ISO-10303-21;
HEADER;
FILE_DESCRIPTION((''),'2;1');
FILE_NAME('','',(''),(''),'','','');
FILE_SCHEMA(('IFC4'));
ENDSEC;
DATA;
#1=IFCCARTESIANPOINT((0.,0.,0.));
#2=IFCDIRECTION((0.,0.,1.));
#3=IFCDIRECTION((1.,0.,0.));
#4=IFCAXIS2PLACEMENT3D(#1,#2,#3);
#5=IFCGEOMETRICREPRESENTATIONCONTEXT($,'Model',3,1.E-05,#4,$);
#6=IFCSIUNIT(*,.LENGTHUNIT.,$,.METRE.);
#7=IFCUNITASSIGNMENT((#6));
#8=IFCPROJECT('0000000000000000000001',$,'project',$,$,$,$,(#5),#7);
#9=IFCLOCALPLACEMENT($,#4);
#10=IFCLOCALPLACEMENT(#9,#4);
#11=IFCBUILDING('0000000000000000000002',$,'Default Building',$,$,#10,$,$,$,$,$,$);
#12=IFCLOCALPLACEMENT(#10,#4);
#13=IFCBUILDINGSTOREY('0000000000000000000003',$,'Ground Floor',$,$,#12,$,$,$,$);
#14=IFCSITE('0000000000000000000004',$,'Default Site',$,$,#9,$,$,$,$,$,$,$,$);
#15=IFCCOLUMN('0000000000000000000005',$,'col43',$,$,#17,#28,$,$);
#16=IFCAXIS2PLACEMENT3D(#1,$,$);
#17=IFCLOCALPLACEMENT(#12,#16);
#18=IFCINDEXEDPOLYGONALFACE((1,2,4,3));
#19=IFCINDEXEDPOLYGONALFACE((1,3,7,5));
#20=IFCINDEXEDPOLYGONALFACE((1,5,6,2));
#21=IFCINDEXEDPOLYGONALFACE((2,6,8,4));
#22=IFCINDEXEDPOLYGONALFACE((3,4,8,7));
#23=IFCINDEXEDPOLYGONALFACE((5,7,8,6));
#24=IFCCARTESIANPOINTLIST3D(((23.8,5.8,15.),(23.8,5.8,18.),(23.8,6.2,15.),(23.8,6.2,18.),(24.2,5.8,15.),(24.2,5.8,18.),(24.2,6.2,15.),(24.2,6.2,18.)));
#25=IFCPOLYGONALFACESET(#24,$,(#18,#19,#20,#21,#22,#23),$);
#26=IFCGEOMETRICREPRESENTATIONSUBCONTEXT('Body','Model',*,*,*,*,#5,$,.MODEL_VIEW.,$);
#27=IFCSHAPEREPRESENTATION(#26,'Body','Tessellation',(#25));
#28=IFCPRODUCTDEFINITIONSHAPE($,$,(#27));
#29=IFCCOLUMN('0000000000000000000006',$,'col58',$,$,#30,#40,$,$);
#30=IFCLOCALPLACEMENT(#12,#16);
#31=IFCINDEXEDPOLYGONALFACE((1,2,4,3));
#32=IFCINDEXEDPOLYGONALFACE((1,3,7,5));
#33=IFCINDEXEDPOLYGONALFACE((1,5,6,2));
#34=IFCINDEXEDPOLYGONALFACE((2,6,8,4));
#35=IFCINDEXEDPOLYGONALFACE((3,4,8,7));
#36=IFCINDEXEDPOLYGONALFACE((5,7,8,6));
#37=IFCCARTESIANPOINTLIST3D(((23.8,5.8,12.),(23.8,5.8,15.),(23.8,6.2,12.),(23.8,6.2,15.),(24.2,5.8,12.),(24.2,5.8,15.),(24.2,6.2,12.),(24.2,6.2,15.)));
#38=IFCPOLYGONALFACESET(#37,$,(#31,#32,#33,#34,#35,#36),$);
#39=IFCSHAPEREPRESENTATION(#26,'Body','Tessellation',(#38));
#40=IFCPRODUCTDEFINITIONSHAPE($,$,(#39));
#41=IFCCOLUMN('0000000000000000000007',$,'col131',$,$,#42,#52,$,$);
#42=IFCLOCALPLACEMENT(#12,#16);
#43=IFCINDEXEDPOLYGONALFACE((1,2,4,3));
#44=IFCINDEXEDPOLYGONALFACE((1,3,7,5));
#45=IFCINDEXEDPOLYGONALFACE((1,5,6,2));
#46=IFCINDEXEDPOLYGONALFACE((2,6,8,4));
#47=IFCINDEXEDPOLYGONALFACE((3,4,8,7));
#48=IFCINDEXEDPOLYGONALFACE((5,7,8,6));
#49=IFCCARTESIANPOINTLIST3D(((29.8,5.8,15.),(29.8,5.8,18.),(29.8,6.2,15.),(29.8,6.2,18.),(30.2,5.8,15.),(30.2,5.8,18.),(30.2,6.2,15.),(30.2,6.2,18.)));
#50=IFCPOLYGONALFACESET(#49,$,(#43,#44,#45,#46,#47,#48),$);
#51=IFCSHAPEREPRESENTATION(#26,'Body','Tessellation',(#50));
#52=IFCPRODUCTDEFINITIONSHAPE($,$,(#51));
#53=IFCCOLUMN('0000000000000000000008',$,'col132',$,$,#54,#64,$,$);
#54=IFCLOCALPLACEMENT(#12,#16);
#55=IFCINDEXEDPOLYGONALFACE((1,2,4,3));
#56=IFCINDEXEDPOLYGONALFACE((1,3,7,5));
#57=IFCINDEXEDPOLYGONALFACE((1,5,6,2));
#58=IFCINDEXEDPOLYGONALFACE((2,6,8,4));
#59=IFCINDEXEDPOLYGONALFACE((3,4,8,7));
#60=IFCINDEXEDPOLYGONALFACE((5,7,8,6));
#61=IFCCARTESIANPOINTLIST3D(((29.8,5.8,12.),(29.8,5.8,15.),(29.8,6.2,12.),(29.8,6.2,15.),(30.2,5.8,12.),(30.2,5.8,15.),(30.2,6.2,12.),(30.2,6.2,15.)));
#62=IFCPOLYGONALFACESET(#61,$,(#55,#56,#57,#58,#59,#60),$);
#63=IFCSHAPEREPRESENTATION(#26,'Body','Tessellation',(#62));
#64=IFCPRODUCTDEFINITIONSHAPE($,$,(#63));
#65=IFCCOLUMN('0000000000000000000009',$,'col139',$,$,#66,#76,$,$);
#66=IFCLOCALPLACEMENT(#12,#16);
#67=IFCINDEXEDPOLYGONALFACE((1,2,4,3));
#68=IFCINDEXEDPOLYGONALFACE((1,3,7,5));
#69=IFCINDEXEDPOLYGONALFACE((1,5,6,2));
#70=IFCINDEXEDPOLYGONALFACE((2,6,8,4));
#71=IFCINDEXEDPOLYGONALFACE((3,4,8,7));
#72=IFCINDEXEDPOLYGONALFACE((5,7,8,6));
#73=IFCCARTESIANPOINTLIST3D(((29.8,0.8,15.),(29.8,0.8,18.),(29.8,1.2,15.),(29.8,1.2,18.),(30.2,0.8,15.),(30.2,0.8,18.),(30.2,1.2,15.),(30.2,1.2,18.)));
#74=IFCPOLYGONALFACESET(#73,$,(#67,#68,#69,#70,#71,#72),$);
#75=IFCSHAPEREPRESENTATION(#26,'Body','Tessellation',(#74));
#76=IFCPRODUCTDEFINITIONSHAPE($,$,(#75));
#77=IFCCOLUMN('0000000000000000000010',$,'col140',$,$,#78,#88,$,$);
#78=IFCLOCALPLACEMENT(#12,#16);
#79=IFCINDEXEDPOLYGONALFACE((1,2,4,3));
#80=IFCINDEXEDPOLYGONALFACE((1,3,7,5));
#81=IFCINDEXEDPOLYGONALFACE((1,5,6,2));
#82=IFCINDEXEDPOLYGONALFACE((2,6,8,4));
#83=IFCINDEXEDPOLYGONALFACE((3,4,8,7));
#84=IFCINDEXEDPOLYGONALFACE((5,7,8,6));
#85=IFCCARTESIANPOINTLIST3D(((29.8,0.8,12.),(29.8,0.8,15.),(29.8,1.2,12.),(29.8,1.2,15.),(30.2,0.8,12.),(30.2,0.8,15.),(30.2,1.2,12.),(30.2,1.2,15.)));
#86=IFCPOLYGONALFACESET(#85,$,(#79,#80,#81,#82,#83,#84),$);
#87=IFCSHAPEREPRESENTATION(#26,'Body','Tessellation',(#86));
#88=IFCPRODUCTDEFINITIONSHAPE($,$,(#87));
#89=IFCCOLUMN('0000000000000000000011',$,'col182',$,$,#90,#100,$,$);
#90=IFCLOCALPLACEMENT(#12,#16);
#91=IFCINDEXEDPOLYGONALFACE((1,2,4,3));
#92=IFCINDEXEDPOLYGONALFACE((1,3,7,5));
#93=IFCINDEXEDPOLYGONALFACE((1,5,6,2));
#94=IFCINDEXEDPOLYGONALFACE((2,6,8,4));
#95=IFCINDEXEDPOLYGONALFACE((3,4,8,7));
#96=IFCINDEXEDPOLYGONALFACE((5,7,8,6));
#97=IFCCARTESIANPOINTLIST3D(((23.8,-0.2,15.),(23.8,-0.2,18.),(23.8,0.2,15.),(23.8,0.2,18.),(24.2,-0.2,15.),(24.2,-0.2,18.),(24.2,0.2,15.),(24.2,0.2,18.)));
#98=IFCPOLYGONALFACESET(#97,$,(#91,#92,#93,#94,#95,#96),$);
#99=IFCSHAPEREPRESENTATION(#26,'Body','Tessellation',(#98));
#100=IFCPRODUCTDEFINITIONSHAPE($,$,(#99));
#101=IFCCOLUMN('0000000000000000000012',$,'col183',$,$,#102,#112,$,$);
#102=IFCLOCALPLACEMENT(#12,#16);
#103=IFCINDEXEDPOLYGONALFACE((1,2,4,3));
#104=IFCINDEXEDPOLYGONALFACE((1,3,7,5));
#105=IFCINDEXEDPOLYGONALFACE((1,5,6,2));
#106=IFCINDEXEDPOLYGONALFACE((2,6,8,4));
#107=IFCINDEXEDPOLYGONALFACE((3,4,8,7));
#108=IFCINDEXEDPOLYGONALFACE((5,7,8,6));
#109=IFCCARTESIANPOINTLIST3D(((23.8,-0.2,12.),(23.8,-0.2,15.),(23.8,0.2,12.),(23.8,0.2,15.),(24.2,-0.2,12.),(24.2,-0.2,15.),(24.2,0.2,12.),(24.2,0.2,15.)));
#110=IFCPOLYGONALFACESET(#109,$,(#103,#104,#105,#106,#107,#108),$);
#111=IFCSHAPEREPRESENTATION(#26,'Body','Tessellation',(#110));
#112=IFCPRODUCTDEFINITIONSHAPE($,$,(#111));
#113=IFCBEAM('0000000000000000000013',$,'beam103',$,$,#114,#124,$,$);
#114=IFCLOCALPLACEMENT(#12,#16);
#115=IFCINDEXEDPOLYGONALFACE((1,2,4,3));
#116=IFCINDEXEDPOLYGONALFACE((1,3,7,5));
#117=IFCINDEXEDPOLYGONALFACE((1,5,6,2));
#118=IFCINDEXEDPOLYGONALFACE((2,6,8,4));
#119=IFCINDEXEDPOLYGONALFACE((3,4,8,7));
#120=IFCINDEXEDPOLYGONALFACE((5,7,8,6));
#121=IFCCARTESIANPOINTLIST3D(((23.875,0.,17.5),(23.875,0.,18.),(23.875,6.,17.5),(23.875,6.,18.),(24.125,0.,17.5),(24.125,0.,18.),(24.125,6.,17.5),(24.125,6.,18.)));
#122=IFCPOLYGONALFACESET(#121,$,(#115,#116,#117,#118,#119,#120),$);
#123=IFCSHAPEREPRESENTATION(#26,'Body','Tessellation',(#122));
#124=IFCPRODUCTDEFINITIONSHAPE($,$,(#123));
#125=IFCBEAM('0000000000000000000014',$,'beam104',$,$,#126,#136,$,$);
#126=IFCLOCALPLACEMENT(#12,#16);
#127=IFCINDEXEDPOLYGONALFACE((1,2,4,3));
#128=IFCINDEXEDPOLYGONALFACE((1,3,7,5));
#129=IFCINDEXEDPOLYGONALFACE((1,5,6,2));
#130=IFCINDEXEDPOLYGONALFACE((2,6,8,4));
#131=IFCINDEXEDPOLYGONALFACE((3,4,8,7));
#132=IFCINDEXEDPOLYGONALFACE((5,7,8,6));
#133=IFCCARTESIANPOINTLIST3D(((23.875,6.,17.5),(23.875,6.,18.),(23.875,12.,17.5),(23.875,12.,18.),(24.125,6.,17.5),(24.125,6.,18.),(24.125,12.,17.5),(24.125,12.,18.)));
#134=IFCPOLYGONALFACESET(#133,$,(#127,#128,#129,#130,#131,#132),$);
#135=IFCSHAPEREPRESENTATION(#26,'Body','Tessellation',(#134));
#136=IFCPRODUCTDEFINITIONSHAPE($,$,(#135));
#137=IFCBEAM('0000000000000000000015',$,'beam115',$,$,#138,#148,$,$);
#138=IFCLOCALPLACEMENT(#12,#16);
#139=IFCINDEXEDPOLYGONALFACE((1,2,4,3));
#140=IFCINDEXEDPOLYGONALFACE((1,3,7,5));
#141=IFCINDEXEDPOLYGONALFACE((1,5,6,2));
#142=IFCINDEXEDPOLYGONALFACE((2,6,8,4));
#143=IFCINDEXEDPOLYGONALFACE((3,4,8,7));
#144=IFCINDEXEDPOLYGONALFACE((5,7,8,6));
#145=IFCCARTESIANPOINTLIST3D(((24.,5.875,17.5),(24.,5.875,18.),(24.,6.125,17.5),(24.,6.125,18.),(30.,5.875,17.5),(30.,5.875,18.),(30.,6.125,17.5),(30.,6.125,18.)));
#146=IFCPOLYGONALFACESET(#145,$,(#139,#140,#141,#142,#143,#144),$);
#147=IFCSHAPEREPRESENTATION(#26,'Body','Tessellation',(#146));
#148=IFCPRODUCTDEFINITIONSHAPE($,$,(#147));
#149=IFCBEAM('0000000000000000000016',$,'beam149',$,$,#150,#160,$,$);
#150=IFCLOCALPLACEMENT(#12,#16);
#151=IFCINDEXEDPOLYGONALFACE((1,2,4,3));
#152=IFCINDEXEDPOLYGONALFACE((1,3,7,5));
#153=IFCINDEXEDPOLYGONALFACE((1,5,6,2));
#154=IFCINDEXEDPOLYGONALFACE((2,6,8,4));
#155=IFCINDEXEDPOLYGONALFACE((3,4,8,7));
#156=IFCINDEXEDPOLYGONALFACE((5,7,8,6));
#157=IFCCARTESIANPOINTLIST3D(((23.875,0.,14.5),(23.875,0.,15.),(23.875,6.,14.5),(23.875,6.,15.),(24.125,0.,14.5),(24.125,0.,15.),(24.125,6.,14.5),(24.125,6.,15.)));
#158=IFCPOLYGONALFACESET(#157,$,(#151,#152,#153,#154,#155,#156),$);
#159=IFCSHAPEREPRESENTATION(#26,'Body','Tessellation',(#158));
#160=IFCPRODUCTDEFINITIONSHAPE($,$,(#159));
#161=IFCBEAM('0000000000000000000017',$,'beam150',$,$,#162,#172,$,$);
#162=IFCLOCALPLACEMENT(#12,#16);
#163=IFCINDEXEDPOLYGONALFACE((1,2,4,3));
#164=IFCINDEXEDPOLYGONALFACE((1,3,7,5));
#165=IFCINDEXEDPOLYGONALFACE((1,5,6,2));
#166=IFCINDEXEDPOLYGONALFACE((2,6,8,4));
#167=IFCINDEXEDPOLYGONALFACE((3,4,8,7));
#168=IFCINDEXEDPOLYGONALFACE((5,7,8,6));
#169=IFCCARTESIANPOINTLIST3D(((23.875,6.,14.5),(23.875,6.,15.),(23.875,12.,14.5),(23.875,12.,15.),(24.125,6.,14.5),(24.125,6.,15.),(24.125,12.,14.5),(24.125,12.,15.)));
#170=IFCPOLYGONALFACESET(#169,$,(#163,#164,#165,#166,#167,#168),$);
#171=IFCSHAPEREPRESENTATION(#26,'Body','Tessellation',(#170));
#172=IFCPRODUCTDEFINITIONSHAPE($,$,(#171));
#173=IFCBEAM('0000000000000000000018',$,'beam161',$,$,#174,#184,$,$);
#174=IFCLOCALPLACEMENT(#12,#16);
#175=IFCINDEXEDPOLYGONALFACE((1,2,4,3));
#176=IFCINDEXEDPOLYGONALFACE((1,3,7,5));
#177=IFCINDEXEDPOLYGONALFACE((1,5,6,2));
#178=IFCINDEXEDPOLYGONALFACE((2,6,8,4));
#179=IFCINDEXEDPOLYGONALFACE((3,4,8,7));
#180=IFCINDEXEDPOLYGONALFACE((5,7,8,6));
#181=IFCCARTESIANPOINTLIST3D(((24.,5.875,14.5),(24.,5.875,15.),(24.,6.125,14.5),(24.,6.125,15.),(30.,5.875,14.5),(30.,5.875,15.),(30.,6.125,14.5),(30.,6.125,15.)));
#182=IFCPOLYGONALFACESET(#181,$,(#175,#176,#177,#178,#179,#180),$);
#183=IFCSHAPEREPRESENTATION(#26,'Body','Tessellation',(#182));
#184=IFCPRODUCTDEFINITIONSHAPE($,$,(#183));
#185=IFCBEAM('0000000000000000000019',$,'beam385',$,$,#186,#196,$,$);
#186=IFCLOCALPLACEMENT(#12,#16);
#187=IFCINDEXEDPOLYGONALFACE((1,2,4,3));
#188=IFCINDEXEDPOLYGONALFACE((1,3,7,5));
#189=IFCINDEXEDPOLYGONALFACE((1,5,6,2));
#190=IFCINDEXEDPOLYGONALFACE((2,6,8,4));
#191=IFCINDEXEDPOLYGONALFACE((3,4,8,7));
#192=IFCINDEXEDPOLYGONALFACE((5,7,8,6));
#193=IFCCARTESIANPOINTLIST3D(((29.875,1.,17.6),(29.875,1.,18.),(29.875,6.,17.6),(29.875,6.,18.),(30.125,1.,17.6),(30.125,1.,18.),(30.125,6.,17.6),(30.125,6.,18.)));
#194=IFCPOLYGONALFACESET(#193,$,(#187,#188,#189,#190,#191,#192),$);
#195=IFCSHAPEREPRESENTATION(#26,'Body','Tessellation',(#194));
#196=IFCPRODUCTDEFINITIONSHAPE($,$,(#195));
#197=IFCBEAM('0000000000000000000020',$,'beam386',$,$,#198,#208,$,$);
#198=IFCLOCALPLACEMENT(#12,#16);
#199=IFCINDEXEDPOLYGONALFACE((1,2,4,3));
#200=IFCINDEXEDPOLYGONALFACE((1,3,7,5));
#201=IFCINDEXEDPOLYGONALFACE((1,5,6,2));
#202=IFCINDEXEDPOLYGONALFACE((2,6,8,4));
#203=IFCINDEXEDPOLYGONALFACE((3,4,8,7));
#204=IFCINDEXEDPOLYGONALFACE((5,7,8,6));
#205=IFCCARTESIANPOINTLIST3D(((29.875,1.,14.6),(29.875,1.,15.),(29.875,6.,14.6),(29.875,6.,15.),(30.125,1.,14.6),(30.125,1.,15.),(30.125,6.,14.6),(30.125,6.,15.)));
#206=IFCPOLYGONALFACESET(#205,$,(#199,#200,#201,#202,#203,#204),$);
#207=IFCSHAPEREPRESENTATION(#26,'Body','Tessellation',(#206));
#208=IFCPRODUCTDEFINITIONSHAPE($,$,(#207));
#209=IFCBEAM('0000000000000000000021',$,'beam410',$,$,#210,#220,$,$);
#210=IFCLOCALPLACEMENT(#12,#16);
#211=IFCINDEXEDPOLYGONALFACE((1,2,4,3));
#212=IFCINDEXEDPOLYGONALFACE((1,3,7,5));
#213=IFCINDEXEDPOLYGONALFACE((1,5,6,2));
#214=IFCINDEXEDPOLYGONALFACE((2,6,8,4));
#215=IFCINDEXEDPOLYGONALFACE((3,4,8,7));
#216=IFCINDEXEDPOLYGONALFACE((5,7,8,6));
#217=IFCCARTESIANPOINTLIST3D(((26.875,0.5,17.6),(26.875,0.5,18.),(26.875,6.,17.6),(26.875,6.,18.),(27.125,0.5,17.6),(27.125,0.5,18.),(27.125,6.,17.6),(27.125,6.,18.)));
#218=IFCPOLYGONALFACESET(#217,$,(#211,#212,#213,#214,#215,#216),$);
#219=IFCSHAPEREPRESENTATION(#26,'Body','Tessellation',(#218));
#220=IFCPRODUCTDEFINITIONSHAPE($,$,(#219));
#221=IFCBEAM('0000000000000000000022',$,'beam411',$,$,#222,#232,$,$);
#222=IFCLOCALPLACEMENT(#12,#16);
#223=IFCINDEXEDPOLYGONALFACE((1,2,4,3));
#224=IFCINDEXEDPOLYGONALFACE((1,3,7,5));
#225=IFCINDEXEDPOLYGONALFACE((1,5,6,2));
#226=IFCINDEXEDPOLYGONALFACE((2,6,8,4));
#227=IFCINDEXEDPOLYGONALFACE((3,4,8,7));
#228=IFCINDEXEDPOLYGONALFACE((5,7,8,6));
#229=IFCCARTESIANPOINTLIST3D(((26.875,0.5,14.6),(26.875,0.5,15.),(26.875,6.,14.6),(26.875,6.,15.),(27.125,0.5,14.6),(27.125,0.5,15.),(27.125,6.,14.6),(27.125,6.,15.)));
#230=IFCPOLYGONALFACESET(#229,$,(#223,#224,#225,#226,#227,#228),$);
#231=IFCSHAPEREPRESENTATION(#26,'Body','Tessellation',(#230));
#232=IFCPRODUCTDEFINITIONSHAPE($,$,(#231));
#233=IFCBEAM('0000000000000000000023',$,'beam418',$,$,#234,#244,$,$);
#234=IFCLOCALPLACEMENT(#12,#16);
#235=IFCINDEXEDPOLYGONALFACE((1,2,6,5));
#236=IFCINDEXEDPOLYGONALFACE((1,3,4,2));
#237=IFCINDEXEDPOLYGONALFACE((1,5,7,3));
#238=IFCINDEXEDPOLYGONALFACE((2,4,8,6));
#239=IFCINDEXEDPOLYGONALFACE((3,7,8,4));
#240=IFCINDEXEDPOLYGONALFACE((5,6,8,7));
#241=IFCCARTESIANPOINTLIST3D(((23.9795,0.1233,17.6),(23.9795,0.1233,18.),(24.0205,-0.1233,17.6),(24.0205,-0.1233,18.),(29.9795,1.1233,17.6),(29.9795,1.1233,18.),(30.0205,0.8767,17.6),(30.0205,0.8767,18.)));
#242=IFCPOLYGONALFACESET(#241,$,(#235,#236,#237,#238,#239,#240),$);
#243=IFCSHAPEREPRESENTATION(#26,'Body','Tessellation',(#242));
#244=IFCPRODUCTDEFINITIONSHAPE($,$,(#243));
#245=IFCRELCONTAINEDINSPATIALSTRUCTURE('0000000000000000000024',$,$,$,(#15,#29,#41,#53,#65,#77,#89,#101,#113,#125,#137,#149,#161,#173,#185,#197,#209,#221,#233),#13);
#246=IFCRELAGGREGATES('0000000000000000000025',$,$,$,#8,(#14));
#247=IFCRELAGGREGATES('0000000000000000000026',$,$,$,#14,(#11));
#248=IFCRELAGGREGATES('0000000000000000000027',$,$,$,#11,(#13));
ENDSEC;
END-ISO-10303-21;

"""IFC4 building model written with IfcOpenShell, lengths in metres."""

from ifc_helpers import new_model, si_unit, frame, origin_with_axes, place, context, subcontext, project, spatial, indexed_curve, outline, extrude, element, save


model = new_model("IFC4")

# Units and contexts
model_context = context("Model", 3, precision=1e-05, world=origin_with_axes())
body_context = subcontext(model_context, "Body", "Model", "MODEL_VIEW")
ifc_project = project(units=[si_unit("LENGTHUNIT", "METRE")], contexts=[model_context])

# Site, building, storey
site_placement = place(None, origin_with_axes())
site = spatial("IfcSite", under=ifc_project, at=site_placement, Name="Default Site")
building_placement = place(site_placement, origin_with_axes())
building = spatial("IfcBuilding", under=site, at=building_placement, Name="Default Building")
storey_placement = place(building_placement, origin_with_axes())
storey = spatial("IfcBuildingStorey", under=building, at=storey_placement, Name="Ground Floor")

# Columns
for number, where, z_axis, x_axis, name in (
    (1, (23.8, 5.8, 15.0), (0.0, 0.0, 1.0), (1.0, 0.0, 0.0), "col43"),
    (2, (23.8, 5.8, 12.0), (0.0, 0.0, 1.0), (1.0, 0.0, 0.0), "col58"),
    (3, (29.8, 5.8, 15.0), (0.0, 0.0, 1.0), (1.0, 0.0, 0.0), "col131"),
    (4, (29.8, 5.8, 12.0), (0.0, 0.0, 1.0), (1.0, 0.0, 0.0), "col132"),
    (5, (29.8, 0.8, 15.0), (0.0, 0.0, 1.0), (1.0, 0.0, 0.0), "col139"),
    (6, (29.8, 0.8, 12.0), (0.0, 0.0, 1.0), (1.0, 0.0, 0.0), "col140"),
    (7, (23.8, -0.2, 15.0), (0.0, 0.0, 1.0), (1.0, 0.0, 0.0), "col182"),
    (8, (23.8, -0.2, 12.0), (0.0, 0.0, 1.0), (1.0, 0.0, 0.0), "col183"),
):
    element("IfcColumn", number, at=place(storey_placement, frame(where, z_axis=z_axis, x_axis=x_axis)), inside=storey, Name=name, context=body_context, shape_type="SweptSolid", body=[
        extrude(outline(indexed_curve([(0.0, 0.0), (0.0, 0.4), (0.4, 0.4), (0.4, 0.0), (0.0, 0.0)], self_intersect=False)), origin_with_axes(), (0.0, 0.0, 1.0), 3.0),
    ])

# Beams
for number, where, z_axis, x_axis, name in (
    (9, (24.125, 0.0, 17.5), (0.0, 0.0, 1.0), (0.0, 1.0, 0.0), "beam103"),
    (10, (24.125, 6.0, 17.5), (0.0, 0.0, 1.0), (0.0, 1.0, 0.0), "beam104"),
    (11, (24.0, 5.875, 17.5), (0.0, 0.0, 1.0), (1.0, 0.0, 0.0), "beam115"),
    (12, (24.125, 0.0, 14.5), (0.0, 0.0, 1.0), (0.0, 1.0, 0.0), "beam149"),
    (13, (24.125, 6.0, 14.5), (0.0, 0.0, 1.0), (0.0, 1.0, 0.0), "beam150"),
    (14, (24.0, 5.875, 14.5), (0.0, 0.0, 1.0), (1.0, 0.0, 0.0), "beam161"),
):
    element("IfcBeam", number, at=place(storey_placement, frame(where, z_axis=z_axis, x_axis=x_axis)), inside=storey, Name=name, context=body_context, shape_type="SweptSolid", body=[
        extrude(outline(indexed_curve([(0.0, 0.0), (0.0, 0.25), (6.0, 0.25), (6.0, 0.0), (0.0, 0.0)], self_intersect=False)), origin_with_axes(), (0.0, 0.0, 1.0), 0.5),
    ])
for number, where, z_axis, x_axis, name in (
    (15, (29.875, 6.0, 17.6), (0.0, 0.0, 1.0), (0.0, -1.0, 0.0), "beam385"),
    (16, (29.875, 6.0, 14.6), (0.0, 0.0, 1.0), (0.0, -1.0, 0.0), "beam386"),
):
    element("IfcBeam", number, at=place(storey_placement, frame(where, z_axis=z_axis, x_axis=x_axis)), inside=storey, Name=name, context=body_context, shape_type="SweptSolid", body=[
        extrude(outline(indexed_curve([(0.0, 0.0), (0.0, 0.25), (5.0, 0.25), (5.0, 0.0), (0.0, 0.0)], self_intersect=False)), origin_with_axes(), (0.0, 0.0, 1.0), 0.4),
    ])
for number, where, z_axis, x_axis, name in (
    (17, (26.875, 6.0, 17.6), (0.0, 0.0, 1.0), (0.0, -1.0, 0.0), "beam410"),
    (18, (26.875, 6.0, 14.6), (0.0, 0.0, 1.0), (0.0, -1.0, 0.0), "beam411"),
):
    element("IfcBeam", number, at=place(storey_placement, frame(where, z_axis=z_axis, x_axis=x_axis)), inside=storey, Name=name, context=body_context, shape_type="SweptSolid", body=[
        extrude(outline(indexed_curve([(0.0, 0.0), (0.0, 0.25), (5.5, 0.25), (5.5, 0.0), (0.0, 0.0)], self_intersect=False)), origin_with_axes(), (0.0, 0.0, 1.0), 0.4),
    ])
for number, where, z_axis, x_axis, name in (
    (19, (24.0205, -0.1233, 17.6), (0.0, 0.0, 1.0), (0.986394, 0.164399, 0.0), "beam418"),
):
    element("IfcBeam", number, at=place(storey_placement, frame(where, z_axis=z_axis, x_axis=x_axis)), inside=storey, Name=name, context=body_context, shape_type="SweptSolid", body=[
        extrude(outline(indexed_curve([(0.0, 0.0), (0.0, 0.25), (6.0828, 0.25), (6.0828, 0.0), (0.0, 0.0)], self_intersect=False)), origin_with_axes(), (0.0, 0.0, 1.0), 0.4),
    ])

save(model, "model.ifc")
